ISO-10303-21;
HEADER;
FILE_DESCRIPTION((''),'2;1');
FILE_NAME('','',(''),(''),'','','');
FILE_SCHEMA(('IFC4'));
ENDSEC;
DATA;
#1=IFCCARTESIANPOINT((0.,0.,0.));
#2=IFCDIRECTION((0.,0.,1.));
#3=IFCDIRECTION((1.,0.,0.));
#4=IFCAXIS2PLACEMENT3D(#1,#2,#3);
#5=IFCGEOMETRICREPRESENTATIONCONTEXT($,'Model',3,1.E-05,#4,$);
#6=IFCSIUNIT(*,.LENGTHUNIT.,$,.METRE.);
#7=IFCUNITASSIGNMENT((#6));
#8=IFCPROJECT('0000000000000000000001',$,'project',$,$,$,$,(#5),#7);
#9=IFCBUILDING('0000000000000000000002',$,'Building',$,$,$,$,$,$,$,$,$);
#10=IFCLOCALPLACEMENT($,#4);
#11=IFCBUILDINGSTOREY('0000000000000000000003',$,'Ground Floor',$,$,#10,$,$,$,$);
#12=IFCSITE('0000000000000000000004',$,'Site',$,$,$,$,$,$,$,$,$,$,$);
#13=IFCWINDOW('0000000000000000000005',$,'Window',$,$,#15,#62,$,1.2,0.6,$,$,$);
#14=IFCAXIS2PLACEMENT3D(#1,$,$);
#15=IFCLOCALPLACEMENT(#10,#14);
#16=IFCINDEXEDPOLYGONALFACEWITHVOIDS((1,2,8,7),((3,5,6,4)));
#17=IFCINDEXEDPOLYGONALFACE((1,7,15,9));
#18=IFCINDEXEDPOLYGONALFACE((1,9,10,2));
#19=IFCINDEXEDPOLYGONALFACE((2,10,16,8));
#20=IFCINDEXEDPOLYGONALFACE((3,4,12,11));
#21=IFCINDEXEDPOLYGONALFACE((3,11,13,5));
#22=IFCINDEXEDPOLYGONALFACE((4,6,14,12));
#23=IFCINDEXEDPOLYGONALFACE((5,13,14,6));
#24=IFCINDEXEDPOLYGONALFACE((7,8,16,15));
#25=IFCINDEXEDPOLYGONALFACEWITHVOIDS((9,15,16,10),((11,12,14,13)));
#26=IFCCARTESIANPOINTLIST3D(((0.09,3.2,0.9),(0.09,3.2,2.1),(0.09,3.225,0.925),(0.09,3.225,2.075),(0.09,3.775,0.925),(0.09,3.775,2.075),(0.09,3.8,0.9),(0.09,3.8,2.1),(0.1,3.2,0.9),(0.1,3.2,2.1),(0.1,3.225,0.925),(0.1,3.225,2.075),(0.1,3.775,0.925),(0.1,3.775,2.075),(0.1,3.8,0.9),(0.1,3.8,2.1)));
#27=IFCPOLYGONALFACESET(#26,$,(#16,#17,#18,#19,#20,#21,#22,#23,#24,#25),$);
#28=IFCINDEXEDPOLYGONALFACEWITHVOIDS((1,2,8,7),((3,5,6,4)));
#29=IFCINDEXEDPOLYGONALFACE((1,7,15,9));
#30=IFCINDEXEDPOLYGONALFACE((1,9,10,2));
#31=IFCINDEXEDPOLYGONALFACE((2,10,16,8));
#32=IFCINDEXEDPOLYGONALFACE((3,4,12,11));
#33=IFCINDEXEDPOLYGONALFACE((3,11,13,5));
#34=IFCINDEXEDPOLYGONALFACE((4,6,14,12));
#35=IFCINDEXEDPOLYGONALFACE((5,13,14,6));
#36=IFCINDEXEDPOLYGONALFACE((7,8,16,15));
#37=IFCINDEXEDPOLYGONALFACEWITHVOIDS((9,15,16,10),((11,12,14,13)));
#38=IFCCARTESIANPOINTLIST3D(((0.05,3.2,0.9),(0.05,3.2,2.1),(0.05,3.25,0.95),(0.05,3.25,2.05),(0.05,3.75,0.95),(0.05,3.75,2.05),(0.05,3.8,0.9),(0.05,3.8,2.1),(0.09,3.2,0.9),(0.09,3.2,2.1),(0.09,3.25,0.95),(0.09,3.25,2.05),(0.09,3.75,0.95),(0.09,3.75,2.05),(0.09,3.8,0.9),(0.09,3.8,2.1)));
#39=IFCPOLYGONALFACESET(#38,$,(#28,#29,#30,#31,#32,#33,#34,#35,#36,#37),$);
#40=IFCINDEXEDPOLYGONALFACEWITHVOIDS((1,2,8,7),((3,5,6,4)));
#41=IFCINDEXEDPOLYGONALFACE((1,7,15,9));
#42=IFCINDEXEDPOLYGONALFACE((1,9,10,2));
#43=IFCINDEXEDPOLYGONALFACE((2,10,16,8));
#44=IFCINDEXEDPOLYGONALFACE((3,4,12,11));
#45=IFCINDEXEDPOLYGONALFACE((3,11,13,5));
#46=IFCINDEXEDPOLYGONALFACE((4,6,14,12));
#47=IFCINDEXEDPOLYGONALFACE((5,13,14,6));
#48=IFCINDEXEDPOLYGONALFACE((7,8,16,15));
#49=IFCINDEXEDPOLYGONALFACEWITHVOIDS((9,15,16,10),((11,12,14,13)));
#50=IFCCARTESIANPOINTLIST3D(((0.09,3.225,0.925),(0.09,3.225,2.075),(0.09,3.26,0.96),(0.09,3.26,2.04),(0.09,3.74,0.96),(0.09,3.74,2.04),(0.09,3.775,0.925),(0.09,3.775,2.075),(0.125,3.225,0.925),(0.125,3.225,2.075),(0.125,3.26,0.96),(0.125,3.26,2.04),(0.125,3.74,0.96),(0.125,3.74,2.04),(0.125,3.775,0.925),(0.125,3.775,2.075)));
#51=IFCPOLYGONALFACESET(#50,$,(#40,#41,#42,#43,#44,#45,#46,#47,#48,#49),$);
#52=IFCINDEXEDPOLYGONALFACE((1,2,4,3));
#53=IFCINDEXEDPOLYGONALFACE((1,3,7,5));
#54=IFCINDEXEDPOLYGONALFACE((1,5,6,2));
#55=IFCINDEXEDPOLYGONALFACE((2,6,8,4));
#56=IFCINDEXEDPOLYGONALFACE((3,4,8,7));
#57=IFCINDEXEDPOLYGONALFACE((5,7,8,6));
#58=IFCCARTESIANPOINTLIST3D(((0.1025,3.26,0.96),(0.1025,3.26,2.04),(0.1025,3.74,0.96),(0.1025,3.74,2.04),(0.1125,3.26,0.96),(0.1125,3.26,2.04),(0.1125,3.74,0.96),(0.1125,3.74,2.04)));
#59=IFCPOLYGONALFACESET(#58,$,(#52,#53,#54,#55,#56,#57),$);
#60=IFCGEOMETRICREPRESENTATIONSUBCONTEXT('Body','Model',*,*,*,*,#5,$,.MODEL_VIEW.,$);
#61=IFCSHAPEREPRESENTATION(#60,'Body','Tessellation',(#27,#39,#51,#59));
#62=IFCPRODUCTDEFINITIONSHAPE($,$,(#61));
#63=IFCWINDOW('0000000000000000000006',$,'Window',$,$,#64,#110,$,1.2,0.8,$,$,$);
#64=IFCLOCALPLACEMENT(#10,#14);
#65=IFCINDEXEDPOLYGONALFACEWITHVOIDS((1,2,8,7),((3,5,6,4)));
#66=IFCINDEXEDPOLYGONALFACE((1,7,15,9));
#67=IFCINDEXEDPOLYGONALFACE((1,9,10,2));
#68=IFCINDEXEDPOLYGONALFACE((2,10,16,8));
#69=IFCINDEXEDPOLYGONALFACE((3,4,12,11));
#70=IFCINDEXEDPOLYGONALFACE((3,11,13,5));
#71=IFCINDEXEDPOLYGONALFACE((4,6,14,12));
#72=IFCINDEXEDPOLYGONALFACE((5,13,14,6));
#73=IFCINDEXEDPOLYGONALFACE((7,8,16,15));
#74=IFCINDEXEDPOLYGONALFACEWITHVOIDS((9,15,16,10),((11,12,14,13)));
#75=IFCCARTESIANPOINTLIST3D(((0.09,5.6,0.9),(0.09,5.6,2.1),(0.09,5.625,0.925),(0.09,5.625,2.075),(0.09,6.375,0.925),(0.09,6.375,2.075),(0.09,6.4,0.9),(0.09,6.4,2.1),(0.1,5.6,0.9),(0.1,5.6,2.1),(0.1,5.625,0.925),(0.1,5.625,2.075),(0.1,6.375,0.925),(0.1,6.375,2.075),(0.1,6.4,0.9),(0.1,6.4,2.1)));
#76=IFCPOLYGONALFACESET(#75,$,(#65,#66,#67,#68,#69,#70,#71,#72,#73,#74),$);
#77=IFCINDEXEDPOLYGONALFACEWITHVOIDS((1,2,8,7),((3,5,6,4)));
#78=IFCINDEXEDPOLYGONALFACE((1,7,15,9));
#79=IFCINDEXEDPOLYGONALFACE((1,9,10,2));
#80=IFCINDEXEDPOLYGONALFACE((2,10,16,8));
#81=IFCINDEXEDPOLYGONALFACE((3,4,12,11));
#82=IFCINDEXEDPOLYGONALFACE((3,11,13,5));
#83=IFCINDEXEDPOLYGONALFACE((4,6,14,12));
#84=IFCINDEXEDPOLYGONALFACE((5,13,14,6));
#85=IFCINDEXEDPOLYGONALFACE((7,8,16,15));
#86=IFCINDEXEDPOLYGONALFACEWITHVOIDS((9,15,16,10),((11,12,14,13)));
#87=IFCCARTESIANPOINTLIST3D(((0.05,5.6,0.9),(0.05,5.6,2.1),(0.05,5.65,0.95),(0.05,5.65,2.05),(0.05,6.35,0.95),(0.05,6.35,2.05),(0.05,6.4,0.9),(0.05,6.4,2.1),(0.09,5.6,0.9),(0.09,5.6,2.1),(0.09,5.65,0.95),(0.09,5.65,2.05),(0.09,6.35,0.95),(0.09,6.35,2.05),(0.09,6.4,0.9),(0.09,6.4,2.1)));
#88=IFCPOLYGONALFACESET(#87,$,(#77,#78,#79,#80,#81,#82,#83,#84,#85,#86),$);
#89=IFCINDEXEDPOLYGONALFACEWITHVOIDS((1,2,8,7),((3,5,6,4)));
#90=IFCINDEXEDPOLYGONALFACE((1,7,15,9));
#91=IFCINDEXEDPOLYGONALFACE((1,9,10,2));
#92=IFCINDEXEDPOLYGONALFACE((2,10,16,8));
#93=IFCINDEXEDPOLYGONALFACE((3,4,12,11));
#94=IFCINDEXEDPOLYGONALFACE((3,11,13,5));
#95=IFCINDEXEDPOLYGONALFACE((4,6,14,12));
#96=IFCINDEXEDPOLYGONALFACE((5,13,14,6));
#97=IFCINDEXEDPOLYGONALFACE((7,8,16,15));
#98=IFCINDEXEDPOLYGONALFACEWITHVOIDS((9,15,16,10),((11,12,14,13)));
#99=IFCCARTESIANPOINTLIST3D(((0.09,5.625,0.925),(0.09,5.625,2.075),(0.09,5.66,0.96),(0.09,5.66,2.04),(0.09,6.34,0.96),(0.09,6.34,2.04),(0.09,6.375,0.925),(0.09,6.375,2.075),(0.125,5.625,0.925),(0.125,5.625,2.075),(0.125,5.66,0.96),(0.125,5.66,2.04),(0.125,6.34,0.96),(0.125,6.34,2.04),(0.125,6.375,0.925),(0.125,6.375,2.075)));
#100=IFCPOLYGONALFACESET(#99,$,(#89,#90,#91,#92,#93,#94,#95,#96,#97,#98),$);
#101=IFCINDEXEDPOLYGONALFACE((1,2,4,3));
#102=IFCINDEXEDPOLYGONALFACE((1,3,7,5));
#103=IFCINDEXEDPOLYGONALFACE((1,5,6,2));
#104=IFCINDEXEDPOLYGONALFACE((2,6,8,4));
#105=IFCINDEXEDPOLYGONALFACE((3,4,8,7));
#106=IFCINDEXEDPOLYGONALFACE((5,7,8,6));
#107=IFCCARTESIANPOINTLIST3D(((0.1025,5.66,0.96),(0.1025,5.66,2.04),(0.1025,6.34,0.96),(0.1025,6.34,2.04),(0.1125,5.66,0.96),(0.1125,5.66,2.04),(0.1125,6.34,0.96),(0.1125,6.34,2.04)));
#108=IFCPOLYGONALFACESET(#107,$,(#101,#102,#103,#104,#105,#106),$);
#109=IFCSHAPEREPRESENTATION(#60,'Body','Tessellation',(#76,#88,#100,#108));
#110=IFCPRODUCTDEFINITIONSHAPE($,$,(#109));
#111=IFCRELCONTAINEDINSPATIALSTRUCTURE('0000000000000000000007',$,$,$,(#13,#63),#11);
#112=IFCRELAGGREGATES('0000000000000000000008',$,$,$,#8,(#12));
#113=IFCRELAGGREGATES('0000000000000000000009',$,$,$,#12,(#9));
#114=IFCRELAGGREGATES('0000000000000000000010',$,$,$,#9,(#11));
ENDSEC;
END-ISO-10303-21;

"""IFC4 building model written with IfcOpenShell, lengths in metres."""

from ifc_helpers import new_model, si_unit, frame, origin_with_axes, place, context, subcontext, project, spatial, line, indexed_curve, outline, extrude, element, save


model = new_model("IFC4")

# Units and contexts
model_context = context("Model", 3, precision=1e-05, world=origin_with_axes())
body_context = subcontext(model_context, "Body", "Model", "MODEL_VIEW")
ifc_project = project(units=[si_unit("LENGTHUNIT", "METRE")], contexts=[model_context])

# Site, building, storey
site = spatial("IfcSite", under=ifc_project, Name="Site")
building = spatial("IfcBuilding", under=site, Name="Building")
storey_placement = place(None, origin_with_axes())
storey = spatial("IfcBuildingStorey", under=building, at=storey_placement, Name="Ground Floor")

# Windows
window_1_placement = place(storey_placement, frame((0.0, 3.8, 0.9), z_axis=(0.0, 0.0, 1.0), x_axis=(0.0, -1.0, 0.0)))
element("IfcWindow", 1, at=window_1_placement, inside=storey, Name="Window", OverallHeight=1.2, OverallWidth=0.6, context=body_context, shape_type="SweptSolid", body=[
    extrude(outline(indexed_curve([(0.0, 0.0), (0.6, 0.0), (0.6, 1.2), (0.0, 1.2)], segments=[line(1, 2, 3, 4, 1)]), holes=[indexed_curve([(0.025, 0.025), (0.575, 0.025), (0.575, 1.175), (0.025, 1.175)], segments=[line(1, 2, 3, 4, 1)])]), frame((0.0, 0.09, 0.0), z_axis=(0.0, -1.0, 0.0), x_axis=(1.0, 0.0, 0.0)), (0.0, 0.0, -1.0), 0.01),
    extrude(outline(indexed_curve([(0.0, 0.0), (0.6, 0.0), (0.6, 1.2), (0.0, 1.2)], segments=[line(1, 2, 3, 4, 1)]), holes=[indexed_curve([(0.05, 0.05), (0.55, 0.05), (0.55, 1.15), (0.05, 1.15)], segments=[line(1, 2, 3, 4, 1)])]), frame((0.0, 0.05, 0.0), z_axis=(0.0, -1.0, 0.0), x_axis=(1.0, 0.0, 0.0)), (0.0, 0.0, -1.0), 0.04),
    extrude(outline(indexed_curve([(0.0, 0.0), (0.55, 0.0), (0.55, 1.15), (0.0, 1.15)], segments=[line(1, 2, 3, 4, 1)]), holes=[indexed_curve([(0.035, 0.035), (0.515, 0.035), (0.515, 1.115), (0.035, 1.115)], segments=[line(1, 2, 3, 4, 1)])]), frame((0.025, 0.09, 0.025), z_axis=(0.0, -1.0, 0.0), x_axis=(1.0, 0.0, 0.0)), (0.0, 0.0, -1.0), 0.035),
    extrude(outline(indexed_curve([(0.035, 0.035), (0.515, 0.035), (0.515, 1.115), (0.035, 1.115)], segments=[line(1, 2, 3, 4, 1)])), frame((0.025, 0.1025, 0.025), z_axis=(0.0, -1.0, 0.0), x_axis=(1.0, 0.0, 0.0)), (0.0, 0.0, -1.0), 0.01),
])
window_2_placement = place(storey_placement, frame((0.0, 6.4, 0.9), z_axis=(0.0, 0.0, 1.0), x_axis=(0.0, -1.0, 0.0)))
element("IfcWindow", 2, at=window_2_placement, inside=storey, Name="Window", OverallHeight=1.2, OverallWidth=0.8, context=body_context, shape_type="SweptSolid", body=[
    extrude(outline(indexed_curve([(0.0, 0.0), (0.8, 0.0), (0.8, 1.2), (0.0, 1.2)], segments=[line(1, 2, 3, 4, 1)]), holes=[indexed_curve([(0.025, 0.025), (0.775, 0.025), (0.775, 1.175), (0.025, 1.175)], segments=[line(1, 2, 3, 4, 1)])]), frame((0.0, 0.09, 0.0), z_axis=(0.0, -1.0, 0.0), x_axis=(1.0, 0.0, 0.0)), (0.0, 0.0, -1.0), 0.01),
    extrude(outline(indexed_curve([(0.0, 0.0), (0.8, 0.0), (0.8, 1.2), (0.0, 1.2)], segments=[line(1, 2, 3, 4, 1)]), holes=[indexed_curve([(0.05, 0.05), (0.75, 0.05), (0.75, 1.15), (0.05, 1.15)], segments=[line(1, 2, 3, 4, 1)])]), frame((0.0, 0.05, 0.0), z_axis=(0.0, -1.0, 0.0), x_axis=(1.0, 0.0, 0.0)), (0.0, 0.0, -1.0), 0.04),
    extrude(outline(indexed_curve([(0.0, 0.0), (0.75, 0.0), (0.75, 1.15), (0.0, 1.15)], segments=[line(1, 2, 3, 4, 1)]), holes=[indexed_curve([(0.035, 0.035), (0.715, 0.035), (0.715, 1.115), (0.035, 1.115)], segments=[line(1, 2, 3, 4, 1)])]), frame((0.025, 0.09, 0.025), z_axis=(0.0, -1.0, 0.0), x_axis=(1.0, 0.0, 0.0)), (0.0, 0.0, -1.0), 0.035),
    extrude(outline(indexed_curve([(0.035, 0.035), (0.715, 0.035), (0.715, 1.115), (0.035, 1.115)], segments=[line(1, 2, 3, 4, 1)])), frame((0.025, 0.1025, 0.025), z_axis=(0.0, -1.0, 0.0), x_axis=(1.0, 0.0, 0.0)), (0.0, 0.0, -1.0), 0.01),
])

save(model, "model.ifc")
